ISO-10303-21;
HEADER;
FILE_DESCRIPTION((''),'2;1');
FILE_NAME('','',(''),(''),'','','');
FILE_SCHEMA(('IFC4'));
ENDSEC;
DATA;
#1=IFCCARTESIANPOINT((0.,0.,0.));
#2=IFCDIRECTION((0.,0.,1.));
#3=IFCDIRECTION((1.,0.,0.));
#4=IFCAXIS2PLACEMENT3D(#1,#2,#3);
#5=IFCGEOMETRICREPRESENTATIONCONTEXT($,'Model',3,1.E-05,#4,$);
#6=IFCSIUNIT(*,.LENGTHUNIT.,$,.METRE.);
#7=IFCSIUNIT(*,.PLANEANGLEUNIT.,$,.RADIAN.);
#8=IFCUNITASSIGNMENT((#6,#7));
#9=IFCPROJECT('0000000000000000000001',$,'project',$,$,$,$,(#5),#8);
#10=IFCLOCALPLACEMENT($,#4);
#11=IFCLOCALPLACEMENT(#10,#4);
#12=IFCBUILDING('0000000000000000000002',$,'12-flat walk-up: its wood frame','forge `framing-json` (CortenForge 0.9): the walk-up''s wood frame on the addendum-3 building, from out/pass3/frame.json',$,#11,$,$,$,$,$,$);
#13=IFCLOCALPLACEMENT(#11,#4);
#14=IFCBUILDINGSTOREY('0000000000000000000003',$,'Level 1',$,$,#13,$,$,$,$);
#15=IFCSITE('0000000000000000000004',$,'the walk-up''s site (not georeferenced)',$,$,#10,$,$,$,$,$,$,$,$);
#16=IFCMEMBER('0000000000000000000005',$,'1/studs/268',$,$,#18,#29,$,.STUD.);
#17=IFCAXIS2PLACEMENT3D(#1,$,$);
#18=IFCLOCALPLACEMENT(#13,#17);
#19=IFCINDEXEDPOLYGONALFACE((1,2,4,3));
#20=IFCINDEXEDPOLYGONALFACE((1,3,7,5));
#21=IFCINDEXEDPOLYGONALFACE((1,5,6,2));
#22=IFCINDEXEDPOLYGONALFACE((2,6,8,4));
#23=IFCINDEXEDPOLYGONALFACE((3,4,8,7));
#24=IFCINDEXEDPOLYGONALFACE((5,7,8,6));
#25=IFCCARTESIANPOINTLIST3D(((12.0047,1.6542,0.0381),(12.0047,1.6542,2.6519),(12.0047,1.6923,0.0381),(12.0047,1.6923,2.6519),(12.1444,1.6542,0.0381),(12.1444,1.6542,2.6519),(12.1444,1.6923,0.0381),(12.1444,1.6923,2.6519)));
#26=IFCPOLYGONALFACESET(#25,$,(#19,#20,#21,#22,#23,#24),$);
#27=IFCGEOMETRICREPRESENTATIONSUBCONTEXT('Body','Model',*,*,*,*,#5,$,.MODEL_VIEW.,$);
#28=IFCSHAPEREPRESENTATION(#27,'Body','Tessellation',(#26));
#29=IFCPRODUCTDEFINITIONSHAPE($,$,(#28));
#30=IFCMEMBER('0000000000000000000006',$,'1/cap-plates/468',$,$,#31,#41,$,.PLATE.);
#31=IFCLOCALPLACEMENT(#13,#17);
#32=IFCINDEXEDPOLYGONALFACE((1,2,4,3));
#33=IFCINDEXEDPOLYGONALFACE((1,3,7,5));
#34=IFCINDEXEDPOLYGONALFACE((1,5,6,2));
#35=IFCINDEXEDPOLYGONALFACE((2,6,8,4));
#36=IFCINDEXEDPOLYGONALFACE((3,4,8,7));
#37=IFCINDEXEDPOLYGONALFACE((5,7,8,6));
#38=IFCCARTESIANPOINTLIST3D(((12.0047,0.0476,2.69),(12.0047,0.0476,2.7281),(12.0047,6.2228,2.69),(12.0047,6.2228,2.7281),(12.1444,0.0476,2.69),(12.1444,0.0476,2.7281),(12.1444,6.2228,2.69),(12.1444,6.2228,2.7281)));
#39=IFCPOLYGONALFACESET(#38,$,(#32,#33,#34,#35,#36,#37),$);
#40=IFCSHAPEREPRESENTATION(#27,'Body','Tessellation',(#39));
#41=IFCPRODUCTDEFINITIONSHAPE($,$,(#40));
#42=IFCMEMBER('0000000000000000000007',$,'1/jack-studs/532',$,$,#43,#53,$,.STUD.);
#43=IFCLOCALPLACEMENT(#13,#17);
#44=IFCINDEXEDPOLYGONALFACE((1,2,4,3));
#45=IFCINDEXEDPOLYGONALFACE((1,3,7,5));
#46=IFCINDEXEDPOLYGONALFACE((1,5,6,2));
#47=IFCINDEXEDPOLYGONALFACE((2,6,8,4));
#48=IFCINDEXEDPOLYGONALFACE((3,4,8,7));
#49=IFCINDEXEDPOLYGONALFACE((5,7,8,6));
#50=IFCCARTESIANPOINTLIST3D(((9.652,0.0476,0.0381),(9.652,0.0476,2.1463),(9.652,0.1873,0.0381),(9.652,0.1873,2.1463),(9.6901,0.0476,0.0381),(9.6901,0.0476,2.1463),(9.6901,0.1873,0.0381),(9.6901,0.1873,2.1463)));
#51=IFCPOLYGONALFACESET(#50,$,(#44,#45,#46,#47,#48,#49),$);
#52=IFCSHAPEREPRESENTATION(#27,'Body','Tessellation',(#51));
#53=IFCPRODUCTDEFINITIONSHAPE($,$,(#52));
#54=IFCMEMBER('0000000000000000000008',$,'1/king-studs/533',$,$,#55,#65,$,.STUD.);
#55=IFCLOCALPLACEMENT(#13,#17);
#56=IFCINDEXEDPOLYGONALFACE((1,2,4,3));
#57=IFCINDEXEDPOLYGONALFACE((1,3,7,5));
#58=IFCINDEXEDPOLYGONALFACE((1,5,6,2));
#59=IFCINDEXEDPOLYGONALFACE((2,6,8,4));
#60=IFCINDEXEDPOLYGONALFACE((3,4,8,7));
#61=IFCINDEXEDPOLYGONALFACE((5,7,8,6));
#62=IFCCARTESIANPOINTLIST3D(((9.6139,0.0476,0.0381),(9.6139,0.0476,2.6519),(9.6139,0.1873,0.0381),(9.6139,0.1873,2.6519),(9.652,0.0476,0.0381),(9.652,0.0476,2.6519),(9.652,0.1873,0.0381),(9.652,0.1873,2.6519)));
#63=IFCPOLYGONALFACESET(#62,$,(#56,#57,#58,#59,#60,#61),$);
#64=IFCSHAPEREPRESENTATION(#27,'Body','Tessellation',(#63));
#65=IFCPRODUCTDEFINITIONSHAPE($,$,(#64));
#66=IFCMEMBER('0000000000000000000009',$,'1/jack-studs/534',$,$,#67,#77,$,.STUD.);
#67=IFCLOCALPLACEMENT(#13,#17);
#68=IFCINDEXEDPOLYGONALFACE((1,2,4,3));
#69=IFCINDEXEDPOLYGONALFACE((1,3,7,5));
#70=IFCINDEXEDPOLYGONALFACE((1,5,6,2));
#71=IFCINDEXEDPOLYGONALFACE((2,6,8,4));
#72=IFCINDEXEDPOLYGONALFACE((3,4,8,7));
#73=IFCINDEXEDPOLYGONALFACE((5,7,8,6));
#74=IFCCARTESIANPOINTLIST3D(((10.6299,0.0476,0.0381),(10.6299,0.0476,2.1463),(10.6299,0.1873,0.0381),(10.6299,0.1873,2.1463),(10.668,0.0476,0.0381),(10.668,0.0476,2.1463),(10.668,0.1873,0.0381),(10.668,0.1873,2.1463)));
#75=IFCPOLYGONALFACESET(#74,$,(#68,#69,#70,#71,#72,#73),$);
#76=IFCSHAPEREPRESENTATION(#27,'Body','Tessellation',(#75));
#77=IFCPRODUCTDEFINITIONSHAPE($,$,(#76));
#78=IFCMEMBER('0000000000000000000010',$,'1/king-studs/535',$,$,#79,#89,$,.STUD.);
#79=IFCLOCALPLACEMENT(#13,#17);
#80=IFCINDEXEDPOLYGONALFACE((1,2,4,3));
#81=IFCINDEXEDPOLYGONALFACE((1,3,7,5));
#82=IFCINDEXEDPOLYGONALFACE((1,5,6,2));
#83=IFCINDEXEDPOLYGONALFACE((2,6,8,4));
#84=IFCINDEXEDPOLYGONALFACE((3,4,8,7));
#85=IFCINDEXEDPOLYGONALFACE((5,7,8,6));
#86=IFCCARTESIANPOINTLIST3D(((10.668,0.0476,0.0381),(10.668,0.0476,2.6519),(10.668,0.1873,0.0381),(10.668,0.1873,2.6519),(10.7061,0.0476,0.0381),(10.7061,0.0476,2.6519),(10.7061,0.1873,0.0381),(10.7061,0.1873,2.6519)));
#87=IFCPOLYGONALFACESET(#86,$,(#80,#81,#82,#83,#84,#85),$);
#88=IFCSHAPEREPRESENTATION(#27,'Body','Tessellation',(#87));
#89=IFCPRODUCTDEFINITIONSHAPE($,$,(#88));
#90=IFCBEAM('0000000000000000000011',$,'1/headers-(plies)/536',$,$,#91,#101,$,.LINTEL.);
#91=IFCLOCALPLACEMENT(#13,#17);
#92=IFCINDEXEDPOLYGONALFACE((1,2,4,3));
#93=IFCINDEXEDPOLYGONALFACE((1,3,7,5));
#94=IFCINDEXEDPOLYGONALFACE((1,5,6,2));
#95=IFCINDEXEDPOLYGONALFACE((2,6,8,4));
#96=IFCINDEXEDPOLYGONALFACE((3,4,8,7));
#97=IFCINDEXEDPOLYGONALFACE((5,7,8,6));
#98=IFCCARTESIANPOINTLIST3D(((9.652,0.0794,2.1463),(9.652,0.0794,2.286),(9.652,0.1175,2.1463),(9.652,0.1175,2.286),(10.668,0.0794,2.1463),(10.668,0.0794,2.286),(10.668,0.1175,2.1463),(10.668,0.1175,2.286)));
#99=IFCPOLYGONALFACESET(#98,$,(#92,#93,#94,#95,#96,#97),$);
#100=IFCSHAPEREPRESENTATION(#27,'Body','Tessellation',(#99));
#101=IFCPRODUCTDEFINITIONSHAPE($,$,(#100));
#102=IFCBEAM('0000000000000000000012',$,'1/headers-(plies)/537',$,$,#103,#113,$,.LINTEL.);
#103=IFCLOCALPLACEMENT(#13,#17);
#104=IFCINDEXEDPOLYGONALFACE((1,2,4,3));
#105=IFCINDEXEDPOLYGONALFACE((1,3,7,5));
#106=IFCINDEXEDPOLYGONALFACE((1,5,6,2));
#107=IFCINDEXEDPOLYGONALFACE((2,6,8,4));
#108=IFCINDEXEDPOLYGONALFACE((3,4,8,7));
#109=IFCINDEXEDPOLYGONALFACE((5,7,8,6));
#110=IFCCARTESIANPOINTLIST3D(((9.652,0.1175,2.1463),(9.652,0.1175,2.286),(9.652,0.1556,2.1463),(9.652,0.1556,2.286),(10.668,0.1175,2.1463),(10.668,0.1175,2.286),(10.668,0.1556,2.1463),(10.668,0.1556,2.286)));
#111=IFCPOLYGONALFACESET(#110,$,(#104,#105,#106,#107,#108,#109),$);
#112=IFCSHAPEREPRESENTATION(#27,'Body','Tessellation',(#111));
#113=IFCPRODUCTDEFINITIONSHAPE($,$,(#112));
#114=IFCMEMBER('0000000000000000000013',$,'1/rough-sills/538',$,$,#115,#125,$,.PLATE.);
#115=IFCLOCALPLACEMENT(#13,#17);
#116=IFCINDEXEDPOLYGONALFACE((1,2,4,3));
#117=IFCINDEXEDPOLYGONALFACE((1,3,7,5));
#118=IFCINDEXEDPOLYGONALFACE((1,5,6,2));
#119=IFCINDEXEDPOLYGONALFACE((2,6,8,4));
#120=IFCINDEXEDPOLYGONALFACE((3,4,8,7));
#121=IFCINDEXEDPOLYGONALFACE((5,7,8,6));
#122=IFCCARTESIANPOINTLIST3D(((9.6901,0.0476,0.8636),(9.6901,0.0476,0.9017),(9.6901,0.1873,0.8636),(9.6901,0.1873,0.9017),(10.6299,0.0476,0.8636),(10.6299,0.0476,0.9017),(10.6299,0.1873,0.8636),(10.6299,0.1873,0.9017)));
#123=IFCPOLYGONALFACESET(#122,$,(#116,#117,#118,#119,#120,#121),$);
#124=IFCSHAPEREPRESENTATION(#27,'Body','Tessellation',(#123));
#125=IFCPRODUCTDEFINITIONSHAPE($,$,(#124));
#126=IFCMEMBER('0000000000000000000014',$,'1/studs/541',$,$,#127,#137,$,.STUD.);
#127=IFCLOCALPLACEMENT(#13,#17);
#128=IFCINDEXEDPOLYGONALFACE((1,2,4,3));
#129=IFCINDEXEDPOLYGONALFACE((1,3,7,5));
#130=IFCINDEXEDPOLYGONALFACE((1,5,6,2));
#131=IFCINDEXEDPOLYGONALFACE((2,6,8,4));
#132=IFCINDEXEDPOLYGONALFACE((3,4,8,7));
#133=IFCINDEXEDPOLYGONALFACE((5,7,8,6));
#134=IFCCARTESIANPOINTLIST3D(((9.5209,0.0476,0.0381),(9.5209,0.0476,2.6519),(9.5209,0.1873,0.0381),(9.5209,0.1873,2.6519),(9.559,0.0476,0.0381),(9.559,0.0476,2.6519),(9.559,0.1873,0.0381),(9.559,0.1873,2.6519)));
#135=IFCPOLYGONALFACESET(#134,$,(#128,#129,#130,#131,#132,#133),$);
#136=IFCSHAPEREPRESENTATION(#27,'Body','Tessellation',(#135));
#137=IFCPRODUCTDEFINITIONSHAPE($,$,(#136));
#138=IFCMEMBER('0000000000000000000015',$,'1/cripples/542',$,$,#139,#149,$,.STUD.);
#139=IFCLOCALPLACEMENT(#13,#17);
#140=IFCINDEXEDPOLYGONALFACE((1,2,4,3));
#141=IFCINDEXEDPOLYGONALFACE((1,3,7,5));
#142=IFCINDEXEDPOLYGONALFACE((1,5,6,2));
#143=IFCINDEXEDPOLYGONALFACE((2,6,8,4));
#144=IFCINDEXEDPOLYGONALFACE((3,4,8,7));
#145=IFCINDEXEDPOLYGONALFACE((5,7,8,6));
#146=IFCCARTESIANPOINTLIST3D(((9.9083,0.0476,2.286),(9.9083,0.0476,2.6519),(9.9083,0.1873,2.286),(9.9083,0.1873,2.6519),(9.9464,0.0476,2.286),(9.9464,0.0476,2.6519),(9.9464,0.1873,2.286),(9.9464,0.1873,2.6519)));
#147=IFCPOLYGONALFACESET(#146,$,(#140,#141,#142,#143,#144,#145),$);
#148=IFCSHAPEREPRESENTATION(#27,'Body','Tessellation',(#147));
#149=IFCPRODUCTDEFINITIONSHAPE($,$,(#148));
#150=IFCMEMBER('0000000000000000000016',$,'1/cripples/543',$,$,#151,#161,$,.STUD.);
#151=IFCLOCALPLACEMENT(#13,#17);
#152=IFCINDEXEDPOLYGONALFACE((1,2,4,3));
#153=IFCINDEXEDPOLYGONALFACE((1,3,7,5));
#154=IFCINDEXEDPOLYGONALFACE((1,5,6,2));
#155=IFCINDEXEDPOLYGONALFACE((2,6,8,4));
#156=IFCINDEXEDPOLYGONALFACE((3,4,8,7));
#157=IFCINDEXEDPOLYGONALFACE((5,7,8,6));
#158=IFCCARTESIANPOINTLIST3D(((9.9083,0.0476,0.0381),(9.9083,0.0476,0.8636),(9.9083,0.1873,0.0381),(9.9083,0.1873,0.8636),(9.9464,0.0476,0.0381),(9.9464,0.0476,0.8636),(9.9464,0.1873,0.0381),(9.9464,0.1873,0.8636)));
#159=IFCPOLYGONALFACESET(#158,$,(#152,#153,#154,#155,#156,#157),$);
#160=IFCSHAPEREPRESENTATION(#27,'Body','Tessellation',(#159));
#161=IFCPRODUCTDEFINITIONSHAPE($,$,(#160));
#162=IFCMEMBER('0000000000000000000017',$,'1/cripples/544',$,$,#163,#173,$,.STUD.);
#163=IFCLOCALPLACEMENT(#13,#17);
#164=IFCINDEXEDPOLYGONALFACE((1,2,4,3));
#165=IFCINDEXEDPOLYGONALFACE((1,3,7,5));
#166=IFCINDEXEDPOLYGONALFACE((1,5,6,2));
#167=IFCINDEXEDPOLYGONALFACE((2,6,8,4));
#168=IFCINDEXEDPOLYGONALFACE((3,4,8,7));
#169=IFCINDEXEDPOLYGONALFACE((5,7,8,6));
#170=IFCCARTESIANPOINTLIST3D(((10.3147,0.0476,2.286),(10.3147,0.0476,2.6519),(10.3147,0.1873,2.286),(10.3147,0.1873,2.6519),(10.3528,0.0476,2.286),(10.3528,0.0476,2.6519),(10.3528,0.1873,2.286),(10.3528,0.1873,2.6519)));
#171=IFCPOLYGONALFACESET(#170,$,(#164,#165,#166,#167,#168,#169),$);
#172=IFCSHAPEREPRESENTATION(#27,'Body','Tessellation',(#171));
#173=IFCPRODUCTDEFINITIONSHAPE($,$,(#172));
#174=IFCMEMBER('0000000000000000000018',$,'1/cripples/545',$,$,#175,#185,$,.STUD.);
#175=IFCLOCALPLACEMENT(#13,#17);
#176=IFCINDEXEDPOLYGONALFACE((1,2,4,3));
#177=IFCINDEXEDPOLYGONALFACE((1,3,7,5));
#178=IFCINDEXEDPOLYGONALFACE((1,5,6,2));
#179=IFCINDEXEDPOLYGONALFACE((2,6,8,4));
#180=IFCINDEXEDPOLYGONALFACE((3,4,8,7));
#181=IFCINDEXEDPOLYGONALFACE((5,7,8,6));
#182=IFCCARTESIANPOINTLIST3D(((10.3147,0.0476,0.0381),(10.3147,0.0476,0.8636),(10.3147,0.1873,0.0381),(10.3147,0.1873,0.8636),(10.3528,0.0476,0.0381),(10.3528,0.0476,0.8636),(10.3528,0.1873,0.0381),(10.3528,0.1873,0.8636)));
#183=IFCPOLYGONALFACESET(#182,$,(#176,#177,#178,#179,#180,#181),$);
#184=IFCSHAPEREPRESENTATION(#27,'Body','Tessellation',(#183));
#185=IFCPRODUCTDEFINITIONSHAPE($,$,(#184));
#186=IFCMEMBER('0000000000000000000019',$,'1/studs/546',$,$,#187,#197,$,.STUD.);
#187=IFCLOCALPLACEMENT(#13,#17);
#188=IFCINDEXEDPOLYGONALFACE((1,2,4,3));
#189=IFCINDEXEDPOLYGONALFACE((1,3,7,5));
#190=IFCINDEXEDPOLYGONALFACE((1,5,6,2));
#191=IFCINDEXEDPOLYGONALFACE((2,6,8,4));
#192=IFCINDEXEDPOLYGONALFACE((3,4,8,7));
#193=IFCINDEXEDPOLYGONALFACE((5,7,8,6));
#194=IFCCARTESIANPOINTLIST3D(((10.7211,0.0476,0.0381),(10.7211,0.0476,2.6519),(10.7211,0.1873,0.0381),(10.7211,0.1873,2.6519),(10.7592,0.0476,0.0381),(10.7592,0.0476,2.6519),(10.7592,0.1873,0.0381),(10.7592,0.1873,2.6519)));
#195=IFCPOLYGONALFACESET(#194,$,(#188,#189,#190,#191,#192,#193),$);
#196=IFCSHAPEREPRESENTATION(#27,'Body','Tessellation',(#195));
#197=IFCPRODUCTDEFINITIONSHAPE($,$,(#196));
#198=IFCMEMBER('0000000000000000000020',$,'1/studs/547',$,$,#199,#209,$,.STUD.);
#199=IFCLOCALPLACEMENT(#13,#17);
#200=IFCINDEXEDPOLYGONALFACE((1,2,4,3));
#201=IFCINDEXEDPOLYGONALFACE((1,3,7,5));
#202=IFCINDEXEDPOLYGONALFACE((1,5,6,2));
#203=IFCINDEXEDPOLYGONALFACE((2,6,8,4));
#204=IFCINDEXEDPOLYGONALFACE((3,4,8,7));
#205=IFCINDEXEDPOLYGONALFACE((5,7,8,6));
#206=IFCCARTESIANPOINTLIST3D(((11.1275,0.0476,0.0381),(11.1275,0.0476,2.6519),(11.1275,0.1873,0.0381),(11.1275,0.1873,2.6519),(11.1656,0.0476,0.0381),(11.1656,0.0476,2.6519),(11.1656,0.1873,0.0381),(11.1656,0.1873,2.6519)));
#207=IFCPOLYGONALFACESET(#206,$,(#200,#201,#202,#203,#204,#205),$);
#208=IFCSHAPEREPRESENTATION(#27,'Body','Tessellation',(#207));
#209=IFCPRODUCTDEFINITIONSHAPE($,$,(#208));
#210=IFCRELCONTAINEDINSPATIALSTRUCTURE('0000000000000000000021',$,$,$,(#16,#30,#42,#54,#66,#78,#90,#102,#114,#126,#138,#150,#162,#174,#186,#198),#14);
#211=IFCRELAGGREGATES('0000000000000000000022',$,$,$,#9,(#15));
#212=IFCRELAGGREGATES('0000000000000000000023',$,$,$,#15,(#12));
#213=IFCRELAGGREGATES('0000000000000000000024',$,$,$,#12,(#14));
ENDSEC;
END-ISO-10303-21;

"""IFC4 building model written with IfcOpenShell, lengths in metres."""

from ifc_helpers import new_model, si_unit, frame, frame_2d, origin, origin_with_axes, place, context, subcontext, project, spatial, rectangle, extrude, element, save


model = new_model("IFC4")

# Units and contexts
model_context = context("Model", 3, precision=1e-05, world=origin_with_axes())
body_context = subcontext(model_context, "Body", "Model", "MODEL_VIEW")
ifc_project = project(units=[si_unit("LENGTHUNIT", "METRE"), si_unit("PLANEANGLEUNIT", "RADIAN")], contexts=[model_context])

# Site, building, storey
site_placement = place(None, origin_with_axes())
site = spatial("IfcSite", under=ifc_project, at=site_placement, Name="the walk-up's site (not georeferenced)")
building_placement = place(site_placement, origin_with_axes())
building = spatial("IfcBuilding", under=site, at=building_placement, Name="12-flat walk-up: its wood frame", Description="forge `framing-json` (CortenForge 0.9): the walk-up's wood frame on the addendum-3 building, from out/pass3/frame.json")
storey_placement = place(building_placement, origin_with_axes())
storey = spatial("IfcBuildingStorey", under=building, at=storey_placement, Name="Level 1")

# Members
member_1_placement = place(storey_placement, frame((12.0047, 1.6542, 0.0381), z_axis=(0.0, 0.0, 1.0), x_axis=(1.0, 0.0, 0.0)))
element("IfcMember", 1, at=member_1_placement, inside=storey, Name="1/studs/268", PredefinedType="STUD", context=body_context, shape_type="SweptSolid", body=[
    extrude(rectangle(XDim=0.1397, YDim=0.0381, at=frame_2d((0.0698, 0.0191))), origin(), (0.0, 0.0, 1.0), 2.6138),
])
member_2_placement = place(storey_placement, frame((12.0047, 0.0476, 2.69), z_axis=(0.0, 0.0, 1.0), x_axis=(1.0, 0.0, 0.0)))
element("IfcMember", 2, at=member_2_placement, inside=storey, Name="1/cap-plates/468", PredefinedType="PLATE", context=body_context, shape_type="SweptSolid", body=[
    extrude(rectangle(XDim=0.1397, YDim=6.1752, at=frame_2d((0.0698, 3.0876))), origin(), (0.0, 0.0, 1.0), 0.0381),
])
member_3_placement = place(storey_placement, frame((9.652, 0.0476, 0.0381), z_axis=(0.0, 0.0, 1.0), x_axis=(1.0, 0.0, 0.0)))
element("IfcMember", 3, at=member_3_placement, inside=storey, Name="1/jack-studs/532", PredefinedType="STUD", context=body_context, shape_type="SweptSolid", body=[
    extrude(rectangle(XDim=0.0381, YDim=0.1397, at=frame_2d((0.0191, 0.0698))), origin(), (0.0, 0.0, 1.0), 2.1082),
])
member_4_placement = place(storey_placement, frame((9.6139, 0.0476, 0.0381), z_axis=(0.0, 0.0, 1.0), x_axis=(1.0, 0.0, 0.0)))
element("IfcMember", 4, at=member_4_placement, inside=storey, Name="1/king-studs/533", PredefinedType="STUD", context=body_context, shape_type="SweptSolid", body=[
    extrude(rectangle(XDim=0.0381, YDim=0.1397, at=frame_2d((0.0191, 0.0698))), origin(), (0.0, 0.0, 1.0), 2.6138),
])
member_5_placement = place(storey_placement, frame((10.6299, 0.0476, 0.0381), z_axis=(0.0, 0.0, 1.0), x_axis=(1.0, 0.0, 0.0)))
element("IfcMember", 5, at=member_5_placement, inside=storey, Name="1/jack-studs/534", PredefinedType="STUD", context=body_context, shape_type="SweptSolid", body=[
    extrude(rectangle(XDim=0.0381, YDim=0.1397, at=frame_2d((0.0191, 0.0698))), origin(), (0.0, 0.0, 1.0), 2.1082),
])
member_6_placement = place(storey_placement, frame((10.668, 0.0476, 0.0381), z_axis=(0.0, 0.0, 1.0), x_axis=(1.0, 0.0, 0.0)))
element("IfcMember", 6, at=member_6_placement, inside=storey, Name="1/king-studs/535", PredefinedType="STUD", context=body_context, shape_type="SweptSolid", body=[
    extrude(rectangle(XDim=0.0381, YDim=0.1397, at=frame_2d((0.0191, 0.0698))), origin(), (0.0, 0.0, 1.0), 2.6138),
])

# Beams
for number, where, z_axis, x_axis, name in (
    (7, (9.652, 0.0794, 2.1463), (0.0, 0.0, 1.0), (1.0, 0.0, 0.0), "1/headers-(plies)/536"),
    (8, (9.652, 0.1175, 2.1463), (0.0, 0.0, 1.0), (1.0, 0.0, 0.0), "1/headers-(plies)/537"),
):
    element("IfcBeam", number, at=place(storey_placement, frame(where, z_axis=z_axis, x_axis=x_axis)), inside=storey, Name=name, PredefinedType="LINTEL", context=body_context, shape_type="SweptSolid", body=[
        extrude(rectangle(XDim=1.016, YDim=0.0381, at=frame_2d((0.508, 0.019))), origin(), (0.0, 0.0, 1.0), 0.1397),
    ])

# Members
member_7_placement = place(storey_placement, frame((9.6901, 0.0476, 0.8636), z_axis=(0.0, 0.0, 1.0), x_axis=(1.0, 0.0, 0.0)))
element("IfcMember", 9, at=member_7_placement, inside=storey, Name="1/rough-sills/538", PredefinedType="PLATE", context=body_context, shape_type="SweptSolid", body=[
    extrude(rectangle(XDim=0.9398, YDim=0.1397, at=frame_2d((0.4699, 0.0698))), origin(), (0.0, 0.0, 1.0), 0.0381),
])
member_8_placement = place(storey_placement, frame((9.5209, 0.0476, 0.0381), z_axis=(0.0, 0.0, 1.0), x_axis=(1.0, 0.0, 0.0)))
element("IfcMember", 10, at=member_8_placement, inside=storey, Name="1/studs/541", PredefinedType="STUD", context=body_context, shape_type="SweptSolid", body=[
    extrude(rectangle(XDim=0.0381, YDim=0.1397, at=frame_2d((0.0191, 0.0698))), origin(), (0.0, 0.0, 1.0), 2.6138),
])
member_9_placement = place(storey_placement, frame((9.9083, 0.0476, 2.286), z_axis=(0.0, 0.0, 1.0), x_axis=(1.0, 0.0, 0.0)))
element("IfcMember", 11, at=member_9_placement, inside=storey, Name="1/cripples/542", PredefinedType="STUD", context=body_context, shape_type="SweptSolid", body=[
    extrude(rectangle(XDim=0.0381, YDim=0.1397, at=frame_2d((0.0191, 0.0698))), origin(), (0.0, 0.0, 1.0), 0.3659),
])
member_10_placement = place(storey_placement, frame((9.9083, 0.0476, 0.0381), z_axis=(0.0, 0.0, 1.0), x_axis=(1.0, 0.0, 0.0)))
element("IfcMember", 12, at=member_10_placement, inside=storey, Name="1/cripples/543", PredefinedType="STUD", context=body_context, shape_type="SweptSolid", body=[
    extrude(rectangle(XDim=0.0381, YDim=0.1397, at=frame_2d((0.0191, 0.0698))), origin(), (0.0, 0.0, 1.0), 0.8255),
])
member_11_placement = place(storey_placement, frame((10.3147, 0.0476, 2.286), z_axis=(0.0, 0.0, 1.0), x_axis=(1.0, 0.0, 0.0)))
element("IfcMember", 13, at=member_11_placement, inside=storey, Name="1/cripples/544", PredefinedType="STUD", context=body_context, shape_type="SweptSolid", body=[
    extrude(rectangle(XDim=0.0381, YDim=0.1397, at=frame_2d((0.0191, 0.0698))), origin(), (0.0, 0.0, 1.0), 0.3659),
])
member_12_placement = place(storey_placement, frame((10.3147, 0.0476, 0.0381), z_axis=(0.0, 0.0, 1.0), x_axis=(1.0, 0.0, 0.0)))
element("IfcMember", 14, at=member_12_placement, inside=storey, Name="1/cripples/545", PredefinedType="STUD", context=body_context, shape_type="SweptSolid", body=[
    extrude(rectangle(XDim=0.0381, YDim=0.1397, at=frame_2d((0.0191, 0.0698))), origin(), (0.0, 0.0, 1.0), 0.8255),
])
for number, where, z_axis, x_axis, name in (
    (15, (10.7211, 0.0476, 0.0381), (0.0, 0.0, 1.0), (1.0, 0.0, 0.0), "1/studs/546"),
    (16, (11.1275, 0.0476, 0.0381), (0.0, 0.0, 1.0), (1.0, 0.0, 0.0), "1/studs/547"),
):
    element("IfcMember", number, at=place(storey_placement, frame(where, z_axis=z_axis, x_axis=x_axis)), inside=storey, Name=name, PredefinedType="STUD", context=body_context, shape_type="SweptSolid", body=[
        extrude(rectangle(XDim=0.0381, YDim=0.1397, at=frame_2d((0.0191, 0.0698))), origin(), (0.0, 0.0, 1.0), 2.6138),
    ])

save(model, "model.ifc")
